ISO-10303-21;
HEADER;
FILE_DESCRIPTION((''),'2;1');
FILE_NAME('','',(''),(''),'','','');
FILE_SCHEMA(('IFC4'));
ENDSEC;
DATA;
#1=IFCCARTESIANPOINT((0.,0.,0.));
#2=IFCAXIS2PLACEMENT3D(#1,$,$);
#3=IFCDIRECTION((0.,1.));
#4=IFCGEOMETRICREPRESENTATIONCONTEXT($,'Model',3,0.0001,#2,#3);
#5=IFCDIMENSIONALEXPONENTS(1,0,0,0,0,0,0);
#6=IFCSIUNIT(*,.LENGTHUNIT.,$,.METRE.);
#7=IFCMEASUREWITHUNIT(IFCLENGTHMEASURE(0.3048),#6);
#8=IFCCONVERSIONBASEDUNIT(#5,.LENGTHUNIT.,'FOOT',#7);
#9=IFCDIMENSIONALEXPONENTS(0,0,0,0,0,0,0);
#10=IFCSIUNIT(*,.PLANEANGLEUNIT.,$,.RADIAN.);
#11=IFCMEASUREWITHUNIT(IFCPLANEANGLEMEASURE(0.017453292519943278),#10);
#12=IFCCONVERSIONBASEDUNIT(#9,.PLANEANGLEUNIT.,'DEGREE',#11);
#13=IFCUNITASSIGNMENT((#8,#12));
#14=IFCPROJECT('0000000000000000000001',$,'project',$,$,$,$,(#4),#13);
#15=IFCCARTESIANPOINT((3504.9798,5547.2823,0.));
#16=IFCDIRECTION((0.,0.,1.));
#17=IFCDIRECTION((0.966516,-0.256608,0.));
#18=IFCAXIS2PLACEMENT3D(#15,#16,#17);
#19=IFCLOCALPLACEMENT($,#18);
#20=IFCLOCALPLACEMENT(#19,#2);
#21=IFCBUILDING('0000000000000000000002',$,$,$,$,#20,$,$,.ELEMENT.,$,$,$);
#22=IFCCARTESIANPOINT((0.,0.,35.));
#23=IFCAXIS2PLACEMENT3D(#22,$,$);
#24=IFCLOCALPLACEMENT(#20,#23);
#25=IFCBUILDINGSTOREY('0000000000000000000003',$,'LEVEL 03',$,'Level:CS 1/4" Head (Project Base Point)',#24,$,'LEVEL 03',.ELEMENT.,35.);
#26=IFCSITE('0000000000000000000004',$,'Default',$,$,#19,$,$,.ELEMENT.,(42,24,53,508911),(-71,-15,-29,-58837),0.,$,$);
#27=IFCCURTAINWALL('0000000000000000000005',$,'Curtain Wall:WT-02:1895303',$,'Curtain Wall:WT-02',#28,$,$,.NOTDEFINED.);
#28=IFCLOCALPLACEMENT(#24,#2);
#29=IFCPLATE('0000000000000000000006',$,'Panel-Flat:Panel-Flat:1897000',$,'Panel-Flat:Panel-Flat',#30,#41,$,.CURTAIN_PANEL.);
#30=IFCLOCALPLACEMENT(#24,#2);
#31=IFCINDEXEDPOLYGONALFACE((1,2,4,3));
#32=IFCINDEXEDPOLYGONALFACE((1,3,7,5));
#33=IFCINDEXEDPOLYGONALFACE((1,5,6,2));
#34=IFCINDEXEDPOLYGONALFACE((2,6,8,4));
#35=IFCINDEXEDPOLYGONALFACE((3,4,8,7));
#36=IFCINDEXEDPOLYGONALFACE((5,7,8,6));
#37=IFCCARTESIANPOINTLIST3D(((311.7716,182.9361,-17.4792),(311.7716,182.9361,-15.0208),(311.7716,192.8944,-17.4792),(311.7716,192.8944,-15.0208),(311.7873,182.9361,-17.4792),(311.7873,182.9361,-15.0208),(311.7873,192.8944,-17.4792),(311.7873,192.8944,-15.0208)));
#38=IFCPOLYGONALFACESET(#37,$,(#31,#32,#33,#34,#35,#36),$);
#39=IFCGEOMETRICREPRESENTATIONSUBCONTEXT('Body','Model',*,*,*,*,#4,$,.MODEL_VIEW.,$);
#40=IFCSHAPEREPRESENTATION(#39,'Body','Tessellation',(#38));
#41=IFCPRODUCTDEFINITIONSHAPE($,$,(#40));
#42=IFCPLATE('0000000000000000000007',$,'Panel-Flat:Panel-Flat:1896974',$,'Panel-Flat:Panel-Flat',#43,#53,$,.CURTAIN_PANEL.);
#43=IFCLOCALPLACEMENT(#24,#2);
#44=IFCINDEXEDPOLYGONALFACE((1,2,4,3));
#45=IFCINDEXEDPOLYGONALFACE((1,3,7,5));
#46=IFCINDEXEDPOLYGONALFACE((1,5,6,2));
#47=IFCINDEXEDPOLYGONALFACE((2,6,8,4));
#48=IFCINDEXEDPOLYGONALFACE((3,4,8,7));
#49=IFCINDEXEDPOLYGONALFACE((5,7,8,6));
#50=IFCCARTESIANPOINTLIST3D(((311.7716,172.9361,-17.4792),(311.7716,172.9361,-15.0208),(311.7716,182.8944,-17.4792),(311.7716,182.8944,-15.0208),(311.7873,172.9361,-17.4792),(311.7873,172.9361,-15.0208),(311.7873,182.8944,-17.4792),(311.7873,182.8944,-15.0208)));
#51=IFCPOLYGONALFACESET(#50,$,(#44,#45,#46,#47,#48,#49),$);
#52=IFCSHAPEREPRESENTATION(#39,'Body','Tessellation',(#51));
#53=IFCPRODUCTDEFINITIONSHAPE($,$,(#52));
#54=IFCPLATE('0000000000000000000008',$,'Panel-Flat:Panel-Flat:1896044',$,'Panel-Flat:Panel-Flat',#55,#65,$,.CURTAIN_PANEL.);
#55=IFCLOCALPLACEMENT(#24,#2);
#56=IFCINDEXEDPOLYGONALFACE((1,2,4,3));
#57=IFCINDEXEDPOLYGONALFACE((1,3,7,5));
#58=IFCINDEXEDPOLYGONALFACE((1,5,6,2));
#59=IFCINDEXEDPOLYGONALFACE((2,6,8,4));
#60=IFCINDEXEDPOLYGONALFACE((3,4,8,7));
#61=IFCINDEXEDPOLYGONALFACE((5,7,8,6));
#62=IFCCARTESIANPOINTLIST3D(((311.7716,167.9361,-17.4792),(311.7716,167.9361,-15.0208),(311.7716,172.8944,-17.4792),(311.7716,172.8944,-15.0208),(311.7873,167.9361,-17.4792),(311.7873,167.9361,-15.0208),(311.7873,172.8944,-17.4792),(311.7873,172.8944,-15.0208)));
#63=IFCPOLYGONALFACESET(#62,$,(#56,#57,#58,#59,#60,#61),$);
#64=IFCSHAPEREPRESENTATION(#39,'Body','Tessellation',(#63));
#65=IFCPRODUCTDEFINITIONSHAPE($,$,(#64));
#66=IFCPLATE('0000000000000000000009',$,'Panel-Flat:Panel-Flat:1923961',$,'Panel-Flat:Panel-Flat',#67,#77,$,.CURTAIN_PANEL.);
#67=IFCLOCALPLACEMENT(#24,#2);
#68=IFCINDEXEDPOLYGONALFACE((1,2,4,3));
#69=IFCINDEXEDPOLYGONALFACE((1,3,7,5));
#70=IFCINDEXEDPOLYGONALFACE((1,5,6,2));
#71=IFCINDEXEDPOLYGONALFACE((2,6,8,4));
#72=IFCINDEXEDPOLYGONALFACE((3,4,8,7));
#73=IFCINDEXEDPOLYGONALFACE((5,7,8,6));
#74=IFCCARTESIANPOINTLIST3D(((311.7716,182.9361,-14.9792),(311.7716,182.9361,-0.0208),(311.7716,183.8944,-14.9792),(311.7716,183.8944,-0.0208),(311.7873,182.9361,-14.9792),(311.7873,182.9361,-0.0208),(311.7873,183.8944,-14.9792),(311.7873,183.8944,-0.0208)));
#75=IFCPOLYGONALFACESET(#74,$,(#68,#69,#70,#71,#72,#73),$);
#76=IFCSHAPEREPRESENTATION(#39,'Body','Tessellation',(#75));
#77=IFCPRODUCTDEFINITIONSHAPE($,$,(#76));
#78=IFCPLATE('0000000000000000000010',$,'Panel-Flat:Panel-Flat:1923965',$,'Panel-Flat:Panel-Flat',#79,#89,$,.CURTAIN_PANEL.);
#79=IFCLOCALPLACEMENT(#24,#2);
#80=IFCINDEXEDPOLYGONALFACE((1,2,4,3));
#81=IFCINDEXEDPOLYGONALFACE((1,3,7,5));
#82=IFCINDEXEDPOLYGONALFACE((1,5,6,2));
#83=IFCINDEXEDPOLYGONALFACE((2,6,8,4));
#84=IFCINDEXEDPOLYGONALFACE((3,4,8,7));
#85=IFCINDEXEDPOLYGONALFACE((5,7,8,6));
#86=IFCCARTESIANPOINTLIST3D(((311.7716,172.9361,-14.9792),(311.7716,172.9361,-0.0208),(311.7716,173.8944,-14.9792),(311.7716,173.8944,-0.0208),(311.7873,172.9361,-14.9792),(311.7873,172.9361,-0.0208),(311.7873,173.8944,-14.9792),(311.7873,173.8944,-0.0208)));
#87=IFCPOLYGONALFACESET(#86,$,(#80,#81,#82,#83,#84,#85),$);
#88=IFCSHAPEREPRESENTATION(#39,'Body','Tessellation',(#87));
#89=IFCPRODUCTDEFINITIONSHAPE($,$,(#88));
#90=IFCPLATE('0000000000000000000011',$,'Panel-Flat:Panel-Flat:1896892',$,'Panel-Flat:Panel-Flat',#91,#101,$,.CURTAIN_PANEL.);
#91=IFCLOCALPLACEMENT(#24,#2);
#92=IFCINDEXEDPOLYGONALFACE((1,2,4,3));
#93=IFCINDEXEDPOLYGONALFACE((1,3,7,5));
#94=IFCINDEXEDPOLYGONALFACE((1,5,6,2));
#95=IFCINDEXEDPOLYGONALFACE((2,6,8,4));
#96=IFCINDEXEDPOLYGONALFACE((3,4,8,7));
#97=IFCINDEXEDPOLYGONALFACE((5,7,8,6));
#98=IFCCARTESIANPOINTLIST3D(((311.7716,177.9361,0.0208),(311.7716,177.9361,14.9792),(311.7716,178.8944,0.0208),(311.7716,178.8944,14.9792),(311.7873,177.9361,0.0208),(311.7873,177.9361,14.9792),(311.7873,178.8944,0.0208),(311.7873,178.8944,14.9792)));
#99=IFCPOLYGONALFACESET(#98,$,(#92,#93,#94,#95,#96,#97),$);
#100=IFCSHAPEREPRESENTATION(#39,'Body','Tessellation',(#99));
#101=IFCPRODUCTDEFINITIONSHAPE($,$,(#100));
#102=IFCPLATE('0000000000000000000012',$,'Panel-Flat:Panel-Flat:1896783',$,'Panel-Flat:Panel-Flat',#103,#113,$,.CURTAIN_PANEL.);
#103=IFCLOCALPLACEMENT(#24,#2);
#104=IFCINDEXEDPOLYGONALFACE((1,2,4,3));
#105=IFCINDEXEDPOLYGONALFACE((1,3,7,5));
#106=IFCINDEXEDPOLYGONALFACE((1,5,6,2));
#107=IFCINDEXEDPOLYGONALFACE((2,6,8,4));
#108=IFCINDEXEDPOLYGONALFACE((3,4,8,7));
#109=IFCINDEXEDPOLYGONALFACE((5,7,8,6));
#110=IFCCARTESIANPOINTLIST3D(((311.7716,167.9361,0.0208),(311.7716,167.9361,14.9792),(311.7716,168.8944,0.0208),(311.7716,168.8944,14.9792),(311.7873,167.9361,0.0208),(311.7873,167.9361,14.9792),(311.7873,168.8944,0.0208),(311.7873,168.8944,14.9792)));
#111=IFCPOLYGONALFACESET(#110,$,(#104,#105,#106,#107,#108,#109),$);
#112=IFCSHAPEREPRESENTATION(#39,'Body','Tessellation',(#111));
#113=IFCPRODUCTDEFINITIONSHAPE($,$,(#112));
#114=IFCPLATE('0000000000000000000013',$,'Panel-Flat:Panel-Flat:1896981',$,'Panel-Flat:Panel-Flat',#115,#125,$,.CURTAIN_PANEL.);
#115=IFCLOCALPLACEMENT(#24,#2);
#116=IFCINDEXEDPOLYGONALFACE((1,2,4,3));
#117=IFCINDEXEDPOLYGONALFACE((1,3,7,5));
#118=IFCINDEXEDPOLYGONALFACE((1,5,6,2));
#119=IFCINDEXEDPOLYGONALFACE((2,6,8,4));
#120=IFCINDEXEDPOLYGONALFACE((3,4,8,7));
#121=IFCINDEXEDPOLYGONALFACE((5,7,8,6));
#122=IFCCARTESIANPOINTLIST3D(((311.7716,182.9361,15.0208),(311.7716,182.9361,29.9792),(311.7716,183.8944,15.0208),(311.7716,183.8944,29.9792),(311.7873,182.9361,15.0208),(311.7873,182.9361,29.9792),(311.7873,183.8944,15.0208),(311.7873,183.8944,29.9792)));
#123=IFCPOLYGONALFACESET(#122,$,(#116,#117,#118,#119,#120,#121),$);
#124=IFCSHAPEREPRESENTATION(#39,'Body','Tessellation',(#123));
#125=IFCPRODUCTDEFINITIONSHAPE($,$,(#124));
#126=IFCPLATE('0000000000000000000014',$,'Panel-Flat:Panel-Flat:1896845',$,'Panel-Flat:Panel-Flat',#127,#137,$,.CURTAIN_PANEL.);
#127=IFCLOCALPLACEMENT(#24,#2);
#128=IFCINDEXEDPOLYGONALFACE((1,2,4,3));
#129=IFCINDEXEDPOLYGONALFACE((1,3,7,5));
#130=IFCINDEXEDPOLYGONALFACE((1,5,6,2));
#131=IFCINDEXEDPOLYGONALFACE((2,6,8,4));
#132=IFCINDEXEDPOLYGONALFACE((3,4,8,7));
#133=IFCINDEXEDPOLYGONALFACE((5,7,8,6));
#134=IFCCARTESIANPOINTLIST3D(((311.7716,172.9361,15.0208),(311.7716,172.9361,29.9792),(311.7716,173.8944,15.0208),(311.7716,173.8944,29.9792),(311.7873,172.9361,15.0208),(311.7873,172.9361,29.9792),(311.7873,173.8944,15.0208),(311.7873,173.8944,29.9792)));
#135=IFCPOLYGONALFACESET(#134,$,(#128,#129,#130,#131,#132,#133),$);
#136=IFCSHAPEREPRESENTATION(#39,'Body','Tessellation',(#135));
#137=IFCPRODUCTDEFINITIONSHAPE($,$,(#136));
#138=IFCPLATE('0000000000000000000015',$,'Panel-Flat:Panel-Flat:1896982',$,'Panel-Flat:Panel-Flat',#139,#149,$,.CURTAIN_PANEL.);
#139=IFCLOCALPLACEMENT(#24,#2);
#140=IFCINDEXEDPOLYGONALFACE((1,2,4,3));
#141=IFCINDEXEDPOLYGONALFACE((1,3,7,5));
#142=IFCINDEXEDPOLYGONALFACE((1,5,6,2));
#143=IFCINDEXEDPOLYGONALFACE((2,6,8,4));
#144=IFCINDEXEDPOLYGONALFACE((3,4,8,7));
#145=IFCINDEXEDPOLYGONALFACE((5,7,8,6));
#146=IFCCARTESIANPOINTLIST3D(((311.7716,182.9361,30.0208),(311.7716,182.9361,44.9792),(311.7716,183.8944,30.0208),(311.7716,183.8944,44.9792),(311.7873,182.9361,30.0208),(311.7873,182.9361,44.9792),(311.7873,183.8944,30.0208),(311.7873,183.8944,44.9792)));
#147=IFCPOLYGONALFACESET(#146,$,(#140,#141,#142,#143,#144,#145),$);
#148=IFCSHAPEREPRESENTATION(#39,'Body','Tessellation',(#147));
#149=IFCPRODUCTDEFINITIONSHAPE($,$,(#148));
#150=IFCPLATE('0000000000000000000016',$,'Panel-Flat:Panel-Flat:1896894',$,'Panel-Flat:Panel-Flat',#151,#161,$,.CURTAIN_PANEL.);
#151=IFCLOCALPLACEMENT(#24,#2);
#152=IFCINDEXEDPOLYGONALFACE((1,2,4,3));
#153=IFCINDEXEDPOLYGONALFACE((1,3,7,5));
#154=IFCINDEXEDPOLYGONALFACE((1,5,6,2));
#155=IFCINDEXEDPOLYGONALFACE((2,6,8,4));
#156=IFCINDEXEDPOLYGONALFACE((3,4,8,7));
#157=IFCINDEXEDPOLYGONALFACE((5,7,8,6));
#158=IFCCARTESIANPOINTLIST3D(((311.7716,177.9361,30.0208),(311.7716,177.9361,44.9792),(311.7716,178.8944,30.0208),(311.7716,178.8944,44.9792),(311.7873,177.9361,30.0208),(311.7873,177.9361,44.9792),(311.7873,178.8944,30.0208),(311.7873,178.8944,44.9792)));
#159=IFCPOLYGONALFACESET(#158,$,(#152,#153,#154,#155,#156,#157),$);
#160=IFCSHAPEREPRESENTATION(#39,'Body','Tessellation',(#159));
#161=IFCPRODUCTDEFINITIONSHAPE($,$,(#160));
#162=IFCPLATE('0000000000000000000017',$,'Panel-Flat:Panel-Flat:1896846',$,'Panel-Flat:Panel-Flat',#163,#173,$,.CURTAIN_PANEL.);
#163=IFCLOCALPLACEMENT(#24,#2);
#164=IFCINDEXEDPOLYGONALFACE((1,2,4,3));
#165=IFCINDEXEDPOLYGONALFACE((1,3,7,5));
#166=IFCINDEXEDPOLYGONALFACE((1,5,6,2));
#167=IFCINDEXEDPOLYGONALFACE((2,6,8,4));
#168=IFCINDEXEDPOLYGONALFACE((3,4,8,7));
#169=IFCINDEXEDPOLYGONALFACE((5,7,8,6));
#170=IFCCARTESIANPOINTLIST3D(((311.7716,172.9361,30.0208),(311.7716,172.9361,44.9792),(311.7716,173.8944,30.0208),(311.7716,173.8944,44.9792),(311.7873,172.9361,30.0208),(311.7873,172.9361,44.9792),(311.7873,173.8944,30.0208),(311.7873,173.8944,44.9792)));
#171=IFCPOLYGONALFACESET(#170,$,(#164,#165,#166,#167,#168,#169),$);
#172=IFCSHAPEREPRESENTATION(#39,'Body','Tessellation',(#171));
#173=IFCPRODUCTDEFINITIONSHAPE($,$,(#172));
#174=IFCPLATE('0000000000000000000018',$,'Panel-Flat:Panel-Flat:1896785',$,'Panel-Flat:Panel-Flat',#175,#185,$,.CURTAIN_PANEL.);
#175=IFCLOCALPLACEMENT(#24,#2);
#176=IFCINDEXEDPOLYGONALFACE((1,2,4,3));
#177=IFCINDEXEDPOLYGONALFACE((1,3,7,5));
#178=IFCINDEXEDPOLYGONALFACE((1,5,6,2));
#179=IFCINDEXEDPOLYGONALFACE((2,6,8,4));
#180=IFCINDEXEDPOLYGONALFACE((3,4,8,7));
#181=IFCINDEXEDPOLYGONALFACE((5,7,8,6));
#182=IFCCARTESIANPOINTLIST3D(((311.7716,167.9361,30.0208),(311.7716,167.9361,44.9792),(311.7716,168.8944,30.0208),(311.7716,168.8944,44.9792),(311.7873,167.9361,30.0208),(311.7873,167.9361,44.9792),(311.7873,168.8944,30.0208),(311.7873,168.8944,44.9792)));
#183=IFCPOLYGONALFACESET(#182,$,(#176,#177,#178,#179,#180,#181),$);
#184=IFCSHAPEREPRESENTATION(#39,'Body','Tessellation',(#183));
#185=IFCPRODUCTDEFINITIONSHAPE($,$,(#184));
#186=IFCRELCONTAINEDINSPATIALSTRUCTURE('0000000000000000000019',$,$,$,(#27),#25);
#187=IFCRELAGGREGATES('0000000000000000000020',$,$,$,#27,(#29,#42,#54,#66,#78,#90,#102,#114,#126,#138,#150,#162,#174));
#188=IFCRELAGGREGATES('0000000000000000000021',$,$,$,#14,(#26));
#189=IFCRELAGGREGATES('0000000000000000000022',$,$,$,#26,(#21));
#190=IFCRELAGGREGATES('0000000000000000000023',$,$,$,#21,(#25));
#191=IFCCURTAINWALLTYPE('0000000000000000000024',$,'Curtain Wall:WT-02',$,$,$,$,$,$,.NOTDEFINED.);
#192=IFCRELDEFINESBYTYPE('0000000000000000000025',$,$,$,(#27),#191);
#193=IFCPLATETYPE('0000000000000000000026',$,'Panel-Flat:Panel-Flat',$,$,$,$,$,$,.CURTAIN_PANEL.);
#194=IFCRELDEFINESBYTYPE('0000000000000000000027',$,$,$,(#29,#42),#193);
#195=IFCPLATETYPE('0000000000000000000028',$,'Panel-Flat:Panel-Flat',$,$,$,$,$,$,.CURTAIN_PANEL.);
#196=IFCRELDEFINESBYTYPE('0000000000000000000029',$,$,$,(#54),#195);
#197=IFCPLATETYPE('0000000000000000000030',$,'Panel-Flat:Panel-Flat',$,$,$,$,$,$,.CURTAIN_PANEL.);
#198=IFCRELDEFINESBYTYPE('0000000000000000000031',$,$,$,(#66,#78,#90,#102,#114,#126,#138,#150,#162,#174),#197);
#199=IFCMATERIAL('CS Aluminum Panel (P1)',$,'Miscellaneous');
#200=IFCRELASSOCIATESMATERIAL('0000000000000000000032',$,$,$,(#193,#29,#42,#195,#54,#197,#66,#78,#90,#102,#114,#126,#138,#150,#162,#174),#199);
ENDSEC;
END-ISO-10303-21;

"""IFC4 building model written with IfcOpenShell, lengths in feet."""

from ifc_helpers import new_model, entity, si_unit, converted_unit, direction, frame, origin, place, context, subcontext, project, spatial, indexed_curve, outline, extrude, source, transform, mapped, material, type_object, type_shapes, element, aggregate, save


model = new_model("IFC4")

# Units and contexts
model_context = context("Model", 3, precision=0.0001, world=origin(), true_north=direction((0.0, 1.0)))
body_context = subcontext(model_context, "Body", "Model", "MODEL_VIEW")
ifc_project = project(units=[converted_unit("LENGTHUNIT", "FOOT", entity("IfcLengthMeasure", 0.3048), si_unit("LENGTHUNIT", "METRE"), dimensions=[1, 0, 0, 0, 0, 0, 0]), converted_unit("PLANEANGLEUNIT", "DEGREE", entity("IfcPlaneAngleMeasure", 0.017453292519943278), si_unit("PLANEANGLEUNIT", "RADIAN"), dimensions=[0, 0, 0, 0, 0, 0, 0])], contexts=[model_context])

# Site, building, storey
site_placement = place(None, frame((3504.9798, 5547.2823, 0.0), z_axis=(0.0, 0.0, 1.0), x_axis=(0.966516, -0.256608, 0.0)))
site = spatial("IfcSite", under=ifc_project, at=site_placement, Name="Default", CompositionType="ELEMENT", RefLatitude=(42, 24, 53, 508911), RefLongitude=(-71, -15, -29, -58837), RefElevation=0.0)
building_placement = place(site_placement, origin())
building = spatial("IfcBuilding", under=site, at=building_placement, CompositionType="ELEMENT")
storey_placement = place(building_placement, frame((0.0, 0.0, 35.0)))
storey = spatial("IfcBuildingStorey", under=building, at=storey_placement, Name="LEVEL 03", ObjectType="Level:CS 1/4\" Head (Project Base Point)", LongName="LEVEL 03", CompositionType="ELEMENT", Elevation=35.0)

# Curtain wall, plates
curtain_wall_type = type_object("IfcCurtainWallType", Name="Curtain Wall:WT-02", PredefinedType="NOTDEFINED")
curtain_wall_placement = place(storey_placement, frame((0.0, 0.0, -35.0)))
curtain_wall = element("IfcCurtainWall", 1, at=curtain_wall_placement, inside=storey, type_object=curtain_wall_type, Name="Curtain Wall:WT-02:1895303", ObjectType="Curtain Wall:WT-02", PredefinedType="NOTDEFINED")
ifc_material = material(Name="CS Aluminum Panel (P1)", Category="Miscellaneous")
plate_type_1 = type_object("IfcPlateType", Name="Panel-Flat:Panel-Flat", PredefinedType="CURTAIN_PANEL", material=ifc_material)
shared_shape_1 = source(origin(), body_context, "Body", "SweptSolid", [
    extrude(outline(indexed_curve([(-0.0078, -4.9792), (0.0078, -4.9792), (0.0078, 4.9792), (-0.0078, 4.9792), (-0.0078, -4.9792)], self_intersect=False)), frame((0.0, -0.0078, 0.0208), z_axis=(0.0, 0.0, 1.0), x_axis=(0.0, -1.0, 0.0)), (0.0, 0.0, 1.0), 2.4583),
])
type_shapes(plate_type_1, [shared_shape_1])
plate_1_placement = place(curtain_wall_placement, frame((311.7873, 187.9153, 17.5), z_axis=(0.0, 0.0, 1.0), x_axis=(0.0, -1.0, 0.0)))
plate_1 = element("IfcPlate", 2, at=plate_1_placement, type_object=plate_type_1, material=ifc_material, Name="Panel-Flat:Panel-Flat:1897000", ObjectType="Panel-Flat:Panel-Flat", PredefinedType="CURTAIN_PANEL", context=body_context, shape_type="MappedRepresentation", body=[
    mapped(shared_shape_1, transform((0.0, 0.0, 0.0), scale=1.0)),
])
plate_2_placement = place(curtain_wall_placement, frame((311.7873, 177.9153, 17.5), z_axis=(0.0, 0.0, 1.0), x_axis=(0.0, -1.0, 0.0)))
plate_2 = element("IfcPlate", 3, at=plate_2_placement, type_object=plate_type_1, material=ifc_material, Name="Panel-Flat:Panel-Flat:1896974", ObjectType="Panel-Flat:Panel-Flat", PredefinedType="CURTAIN_PANEL", context=body_context, shape_type="MappedRepresentation", body=[
    mapped(shared_shape_1, transform((0.0, 0.0, 0.0), scale=1.0)),
])
plate_type_2 = type_object("IfcPlateType", Name="Panel-Flat:Panel-Flat", PredefinedType="CURTAIN_PANEL", material=ifc_material)
shared_shape_2 = source(origin(), body_context, "Body", "SweptSolid", [
    extrude(outline(indexed_curve([(-0.0078, -2.4792), (0.0078, -2.4792), (0.0078, 2.4792), (-0.0078, 2.4792), (-0.0078, -2.4792)], self_intersect=False)), frame((0.0, -0.0078, 0.0208), z_axis=(0.0, 0.0, 1.0), x_axis=(0.0, -1.0, 0.0)), (0.0, 0.0, 1.0), 2.4583),
])
type_shapes(plate_type_2, [shared_shape_2])
plate_3_placement = place(curtain_wall_placement, frame((311.7873, 170.4153, 17.5), z_axis=(0.0, 0.0, 1.0), x_axis=(0.0, -1.0, 0.0)))
plate_3 = element("IfcPlate", 4, at=plate_3_placement, type_object=plate_type_2, material=ifc_material, Name="Panel-Flat:Panel-Flat:1896044", ObjectType="Panel-Flat:Panel-Flat", PredefinedType="CURTAIN_PANEL", context=body_context, shape_type="MappedRepresentation", body=[
    mapped(shared_shape_2, transform((0.0, 0.0, 0.0), scale=1.0)),
])
plate_type_3 = type_object("IfcPlateType", Name="Panel-Flat:Panel-Flat", PredefinedType="CURTAIN_PANEL", material=ifc_material)
shared_shape_3 = source(origin(), body_context, "Body", "SweptSolid", [
    extrude(outline(indexed_curve([(-0.0078, -0.4792), (0.0078, -0.4792), (0.0078, 0.4792), (-0.0078, 0.4792), (-0.0078, -0.4792)], self_intersect=False)), frame((0.0, -0.0078, 0.0208), z_axis=(0.0, 0.0, 1.0), x_axis=(0.0, -1.0, 0.0)), (0.0, 0.0, 1.0), 14.9583),
])
type_shapes(plate_type_3, [shared_shape_3])
plate_4_placement = place(curtain_wall_placement, frame((311.7873, 183.4153, 20.0), z_axis=(0.0, 0.0, 1.0), x_axis=(0.0, -1.0, 0.0)))
plate_4 = element("IfcPlate", 5, at=plate_4_placement, type_object=plate_type_3, material=ifc_material, Name="Panel-Flat:Panel-Flat:1923961", ObjectType="Panel-Flat:Panel-Flat", PredefinedType="CURTAIN_PANEL", context=body_context, shape_type="MappedRepresentation", body=[
    mapped(shared_shape_3, transform((0.0, 0.0, 0.0), scale=1.0)),
])
plate_5_placement = place(curtain_wall_placement, frame((311.7873, 173.4153, 20.0), z_axis=(0.0, 0.0, 1.0), x_axis=(0.0, -1.0, 0.0)))
plate_5 = element("IfcPlate", 6, at=plate_5_placement, type_object=plate_type_3, material=ifc_material, Name="Panel-Flat:Panel-Flat:1923965", ObjectType="Panel-Flat:Panel-Flat", PredefinedType="CURTAIN_PANEL", context=body_context, shape_type="MappedRepresentation", body=[
    mapped(shared_shape_3, transform((0.0, 0.0, 0.0), scale=1.0)),
])
plate_6_placement = place(curtain_wall_placement, frame((311.7873, 178.4153, 35.0), z_axis=(0.0, 0.0, 1.0), x_axis=(0.0, -1.0, 0.0)))
plate_6 = element("IfcPlate", 7, at=plate_6_placement, type_object=plate_type_3, material=ifc_material, Name="Panel-Flat:Panel-Flat:1896892", ObjectType="Panel-Flat:Panel-Flat", PredefinedType="CURTAIN_PANEL", context=body_context, shape_type="MappedRepresentation", body=[
    mapped(shared_shape_3, transform((0.0, 0.0, 0.0), scale=1.0)),
])
plate_7_placement = place(curtain_wall_placement, frame((311.7873, 168.4153, 35.0), z_axis=(0.0, 0.0, 1.0), x_axis=(0.0, -1.0, 0.0)))
plate_7 = element("IfcPlate", 8, at=plate_7_placement, type_object=plate_type_3, material=ifc_material, Name="Panel-Flat:Panel-Flat:1896783", ObjectType="Panel-Flat:Panel-Flat", PredefinedType="CURTAIN_PANEL", context=body_context, shape_type="MappedRepresentation", body=[
    mapped(shared_shape_3, transform((0.0, 0.0, 0.0), scale=1.0)),
])
plate_8_placement = place(curtain_wall_placement, frame((311.7873, 183.4153, 50.0), z_axis=(0.0, 0.0, 1.0), x_axis=(0.0, -1.0, 0.0)))
plate_8 = element("IfcPlate", 9, at=plate_8_placement, type_object=plate_type_3, material=ifc_material, Name="Panel-Flat:Panel-Flat:1896981", ObjectType="Panel-Flat:Panel-Flat", PredefinedType="CURTAIN_PANEL", context=body_context, shape_type="MappedRepresentation", body=[
    mapped(shared_shape_3, transform((0.0, 0.0, 0.0), scale=1.0)),
])
plate_9_placement = place(curtain_wall_placement, frame((311.7873, 173.4153, 50.0), z_axis=(0.0, 0.0, 1.0), x_axis=(0.0, -1.0, 0.0)))
plate_9 = element("IfcPlate", 10, at=plate_9_placement, type_object=plate_type_3, material=ifc_material, Name="Panel-Flat:Panel-Flat:1896845", ObjectType="Panel-Flat:Panel-Flat", PredefinedType="CURTAIN_PANEL", context=body_context, shape_type="MappedRepresentation", body=[
    mapped(shared_shape_3, transform((0.0, 0.0, 0.0), scale=1.0)),
])
plate_10_placement = place(curtain_wall_placement, frame((311.7873, 183.4153, 65.0), z_axis=(0.0, 0.0, 1.0), x_axis=(0.0, -1.0, 0.0)))
plate_10 = element("IfcPlate", 11, at=plate_10_placement, type_object=plate_type_3, material=ifc_material, Name="Panel-Flat:Panel-Flat:1896982", ObjectType="Panel-Flat:Panel-Flat", PredefinedType="CURTAIN_PANEL", context=body_context, shape_type="MappedRepresentation", body=[
    mapped(shared_shape_3, transform((0.0, 0.0, 0.0), scale=1.0)),
])
plate_11_placement = place(curtain_wall_placement, frame((311.7873, 178.4153, 65.0), z_axis=(0.0, 0.0, 1.0), x_axis=(0.0, -1.0, 0.0)))
plate_11 = element("IfcPlate", 12, at=plate_11_placement, type_object=plate_type_3, material=ifc_material, Name="Panel-Flat:Panel-Flat:1896894", ObjectType="Panel-Flat:Panel-Flat", PredefinedType="CURTAIN_PANEL", context=body_context, shape_type="MappedRepresentation", body=[
    mapped(shared_shape_3, transform((0.0, 0.0, 0.0), scale=1.0)),
])
plate_12_placement = place(curtain_wall_placement, frame((311.7873, 173.4153, 65.0), z_axis=(0.0, 0.0, 1.0), x_axis=(0.0, -1.0, 0.0)))
plate_12 = element("IfcPlate", 13, at=plate_12_placement, type_object=plate_type_3, material=ifc_material, Name="Panel-Flat:Panel-Flat:1896846", ObjectType="Panel-Flat:Panel-Flat", PredefinedType="CURTAIN_PANEL", context=body_context, shape_type="MappedRepresentation", body=[
    mapped(shared_shape_3, transform((0.0, 0.0, 0.0), scale=1.0)),
])
plate_13_placement = place(curtain_wall_placement, frame((311.7873, 168.4153, 65.0), z_axis=(0.0, 0.0, 1.0), x_axis=(0.0, -1.0, 0.0)))
plate_13 = element("IfcPlate", 14, at=plate_13_placement, type_object=plate_type_3, material=ifc_material, Name="Panel-Flat:Panel-Flat:1896785", ObjectType="Panel-Flat:Panel-Flat", PredefinedType="CURTAIN_PANEL", context=body_context, shape_type="MappedRepresentation", body=[
    mapped(shared_shape_3, transform((0.0, 0.0, 0.0), scale=1.0)),
])
aggregate(curtain_wall, [plate_1, plate_2, plate_3, plate_4, plate_5, plate_6, plate_7, plate_8, plate_9, plate_10, plate_11, plate_12, plate_13])

save(model, "model.ifc")
